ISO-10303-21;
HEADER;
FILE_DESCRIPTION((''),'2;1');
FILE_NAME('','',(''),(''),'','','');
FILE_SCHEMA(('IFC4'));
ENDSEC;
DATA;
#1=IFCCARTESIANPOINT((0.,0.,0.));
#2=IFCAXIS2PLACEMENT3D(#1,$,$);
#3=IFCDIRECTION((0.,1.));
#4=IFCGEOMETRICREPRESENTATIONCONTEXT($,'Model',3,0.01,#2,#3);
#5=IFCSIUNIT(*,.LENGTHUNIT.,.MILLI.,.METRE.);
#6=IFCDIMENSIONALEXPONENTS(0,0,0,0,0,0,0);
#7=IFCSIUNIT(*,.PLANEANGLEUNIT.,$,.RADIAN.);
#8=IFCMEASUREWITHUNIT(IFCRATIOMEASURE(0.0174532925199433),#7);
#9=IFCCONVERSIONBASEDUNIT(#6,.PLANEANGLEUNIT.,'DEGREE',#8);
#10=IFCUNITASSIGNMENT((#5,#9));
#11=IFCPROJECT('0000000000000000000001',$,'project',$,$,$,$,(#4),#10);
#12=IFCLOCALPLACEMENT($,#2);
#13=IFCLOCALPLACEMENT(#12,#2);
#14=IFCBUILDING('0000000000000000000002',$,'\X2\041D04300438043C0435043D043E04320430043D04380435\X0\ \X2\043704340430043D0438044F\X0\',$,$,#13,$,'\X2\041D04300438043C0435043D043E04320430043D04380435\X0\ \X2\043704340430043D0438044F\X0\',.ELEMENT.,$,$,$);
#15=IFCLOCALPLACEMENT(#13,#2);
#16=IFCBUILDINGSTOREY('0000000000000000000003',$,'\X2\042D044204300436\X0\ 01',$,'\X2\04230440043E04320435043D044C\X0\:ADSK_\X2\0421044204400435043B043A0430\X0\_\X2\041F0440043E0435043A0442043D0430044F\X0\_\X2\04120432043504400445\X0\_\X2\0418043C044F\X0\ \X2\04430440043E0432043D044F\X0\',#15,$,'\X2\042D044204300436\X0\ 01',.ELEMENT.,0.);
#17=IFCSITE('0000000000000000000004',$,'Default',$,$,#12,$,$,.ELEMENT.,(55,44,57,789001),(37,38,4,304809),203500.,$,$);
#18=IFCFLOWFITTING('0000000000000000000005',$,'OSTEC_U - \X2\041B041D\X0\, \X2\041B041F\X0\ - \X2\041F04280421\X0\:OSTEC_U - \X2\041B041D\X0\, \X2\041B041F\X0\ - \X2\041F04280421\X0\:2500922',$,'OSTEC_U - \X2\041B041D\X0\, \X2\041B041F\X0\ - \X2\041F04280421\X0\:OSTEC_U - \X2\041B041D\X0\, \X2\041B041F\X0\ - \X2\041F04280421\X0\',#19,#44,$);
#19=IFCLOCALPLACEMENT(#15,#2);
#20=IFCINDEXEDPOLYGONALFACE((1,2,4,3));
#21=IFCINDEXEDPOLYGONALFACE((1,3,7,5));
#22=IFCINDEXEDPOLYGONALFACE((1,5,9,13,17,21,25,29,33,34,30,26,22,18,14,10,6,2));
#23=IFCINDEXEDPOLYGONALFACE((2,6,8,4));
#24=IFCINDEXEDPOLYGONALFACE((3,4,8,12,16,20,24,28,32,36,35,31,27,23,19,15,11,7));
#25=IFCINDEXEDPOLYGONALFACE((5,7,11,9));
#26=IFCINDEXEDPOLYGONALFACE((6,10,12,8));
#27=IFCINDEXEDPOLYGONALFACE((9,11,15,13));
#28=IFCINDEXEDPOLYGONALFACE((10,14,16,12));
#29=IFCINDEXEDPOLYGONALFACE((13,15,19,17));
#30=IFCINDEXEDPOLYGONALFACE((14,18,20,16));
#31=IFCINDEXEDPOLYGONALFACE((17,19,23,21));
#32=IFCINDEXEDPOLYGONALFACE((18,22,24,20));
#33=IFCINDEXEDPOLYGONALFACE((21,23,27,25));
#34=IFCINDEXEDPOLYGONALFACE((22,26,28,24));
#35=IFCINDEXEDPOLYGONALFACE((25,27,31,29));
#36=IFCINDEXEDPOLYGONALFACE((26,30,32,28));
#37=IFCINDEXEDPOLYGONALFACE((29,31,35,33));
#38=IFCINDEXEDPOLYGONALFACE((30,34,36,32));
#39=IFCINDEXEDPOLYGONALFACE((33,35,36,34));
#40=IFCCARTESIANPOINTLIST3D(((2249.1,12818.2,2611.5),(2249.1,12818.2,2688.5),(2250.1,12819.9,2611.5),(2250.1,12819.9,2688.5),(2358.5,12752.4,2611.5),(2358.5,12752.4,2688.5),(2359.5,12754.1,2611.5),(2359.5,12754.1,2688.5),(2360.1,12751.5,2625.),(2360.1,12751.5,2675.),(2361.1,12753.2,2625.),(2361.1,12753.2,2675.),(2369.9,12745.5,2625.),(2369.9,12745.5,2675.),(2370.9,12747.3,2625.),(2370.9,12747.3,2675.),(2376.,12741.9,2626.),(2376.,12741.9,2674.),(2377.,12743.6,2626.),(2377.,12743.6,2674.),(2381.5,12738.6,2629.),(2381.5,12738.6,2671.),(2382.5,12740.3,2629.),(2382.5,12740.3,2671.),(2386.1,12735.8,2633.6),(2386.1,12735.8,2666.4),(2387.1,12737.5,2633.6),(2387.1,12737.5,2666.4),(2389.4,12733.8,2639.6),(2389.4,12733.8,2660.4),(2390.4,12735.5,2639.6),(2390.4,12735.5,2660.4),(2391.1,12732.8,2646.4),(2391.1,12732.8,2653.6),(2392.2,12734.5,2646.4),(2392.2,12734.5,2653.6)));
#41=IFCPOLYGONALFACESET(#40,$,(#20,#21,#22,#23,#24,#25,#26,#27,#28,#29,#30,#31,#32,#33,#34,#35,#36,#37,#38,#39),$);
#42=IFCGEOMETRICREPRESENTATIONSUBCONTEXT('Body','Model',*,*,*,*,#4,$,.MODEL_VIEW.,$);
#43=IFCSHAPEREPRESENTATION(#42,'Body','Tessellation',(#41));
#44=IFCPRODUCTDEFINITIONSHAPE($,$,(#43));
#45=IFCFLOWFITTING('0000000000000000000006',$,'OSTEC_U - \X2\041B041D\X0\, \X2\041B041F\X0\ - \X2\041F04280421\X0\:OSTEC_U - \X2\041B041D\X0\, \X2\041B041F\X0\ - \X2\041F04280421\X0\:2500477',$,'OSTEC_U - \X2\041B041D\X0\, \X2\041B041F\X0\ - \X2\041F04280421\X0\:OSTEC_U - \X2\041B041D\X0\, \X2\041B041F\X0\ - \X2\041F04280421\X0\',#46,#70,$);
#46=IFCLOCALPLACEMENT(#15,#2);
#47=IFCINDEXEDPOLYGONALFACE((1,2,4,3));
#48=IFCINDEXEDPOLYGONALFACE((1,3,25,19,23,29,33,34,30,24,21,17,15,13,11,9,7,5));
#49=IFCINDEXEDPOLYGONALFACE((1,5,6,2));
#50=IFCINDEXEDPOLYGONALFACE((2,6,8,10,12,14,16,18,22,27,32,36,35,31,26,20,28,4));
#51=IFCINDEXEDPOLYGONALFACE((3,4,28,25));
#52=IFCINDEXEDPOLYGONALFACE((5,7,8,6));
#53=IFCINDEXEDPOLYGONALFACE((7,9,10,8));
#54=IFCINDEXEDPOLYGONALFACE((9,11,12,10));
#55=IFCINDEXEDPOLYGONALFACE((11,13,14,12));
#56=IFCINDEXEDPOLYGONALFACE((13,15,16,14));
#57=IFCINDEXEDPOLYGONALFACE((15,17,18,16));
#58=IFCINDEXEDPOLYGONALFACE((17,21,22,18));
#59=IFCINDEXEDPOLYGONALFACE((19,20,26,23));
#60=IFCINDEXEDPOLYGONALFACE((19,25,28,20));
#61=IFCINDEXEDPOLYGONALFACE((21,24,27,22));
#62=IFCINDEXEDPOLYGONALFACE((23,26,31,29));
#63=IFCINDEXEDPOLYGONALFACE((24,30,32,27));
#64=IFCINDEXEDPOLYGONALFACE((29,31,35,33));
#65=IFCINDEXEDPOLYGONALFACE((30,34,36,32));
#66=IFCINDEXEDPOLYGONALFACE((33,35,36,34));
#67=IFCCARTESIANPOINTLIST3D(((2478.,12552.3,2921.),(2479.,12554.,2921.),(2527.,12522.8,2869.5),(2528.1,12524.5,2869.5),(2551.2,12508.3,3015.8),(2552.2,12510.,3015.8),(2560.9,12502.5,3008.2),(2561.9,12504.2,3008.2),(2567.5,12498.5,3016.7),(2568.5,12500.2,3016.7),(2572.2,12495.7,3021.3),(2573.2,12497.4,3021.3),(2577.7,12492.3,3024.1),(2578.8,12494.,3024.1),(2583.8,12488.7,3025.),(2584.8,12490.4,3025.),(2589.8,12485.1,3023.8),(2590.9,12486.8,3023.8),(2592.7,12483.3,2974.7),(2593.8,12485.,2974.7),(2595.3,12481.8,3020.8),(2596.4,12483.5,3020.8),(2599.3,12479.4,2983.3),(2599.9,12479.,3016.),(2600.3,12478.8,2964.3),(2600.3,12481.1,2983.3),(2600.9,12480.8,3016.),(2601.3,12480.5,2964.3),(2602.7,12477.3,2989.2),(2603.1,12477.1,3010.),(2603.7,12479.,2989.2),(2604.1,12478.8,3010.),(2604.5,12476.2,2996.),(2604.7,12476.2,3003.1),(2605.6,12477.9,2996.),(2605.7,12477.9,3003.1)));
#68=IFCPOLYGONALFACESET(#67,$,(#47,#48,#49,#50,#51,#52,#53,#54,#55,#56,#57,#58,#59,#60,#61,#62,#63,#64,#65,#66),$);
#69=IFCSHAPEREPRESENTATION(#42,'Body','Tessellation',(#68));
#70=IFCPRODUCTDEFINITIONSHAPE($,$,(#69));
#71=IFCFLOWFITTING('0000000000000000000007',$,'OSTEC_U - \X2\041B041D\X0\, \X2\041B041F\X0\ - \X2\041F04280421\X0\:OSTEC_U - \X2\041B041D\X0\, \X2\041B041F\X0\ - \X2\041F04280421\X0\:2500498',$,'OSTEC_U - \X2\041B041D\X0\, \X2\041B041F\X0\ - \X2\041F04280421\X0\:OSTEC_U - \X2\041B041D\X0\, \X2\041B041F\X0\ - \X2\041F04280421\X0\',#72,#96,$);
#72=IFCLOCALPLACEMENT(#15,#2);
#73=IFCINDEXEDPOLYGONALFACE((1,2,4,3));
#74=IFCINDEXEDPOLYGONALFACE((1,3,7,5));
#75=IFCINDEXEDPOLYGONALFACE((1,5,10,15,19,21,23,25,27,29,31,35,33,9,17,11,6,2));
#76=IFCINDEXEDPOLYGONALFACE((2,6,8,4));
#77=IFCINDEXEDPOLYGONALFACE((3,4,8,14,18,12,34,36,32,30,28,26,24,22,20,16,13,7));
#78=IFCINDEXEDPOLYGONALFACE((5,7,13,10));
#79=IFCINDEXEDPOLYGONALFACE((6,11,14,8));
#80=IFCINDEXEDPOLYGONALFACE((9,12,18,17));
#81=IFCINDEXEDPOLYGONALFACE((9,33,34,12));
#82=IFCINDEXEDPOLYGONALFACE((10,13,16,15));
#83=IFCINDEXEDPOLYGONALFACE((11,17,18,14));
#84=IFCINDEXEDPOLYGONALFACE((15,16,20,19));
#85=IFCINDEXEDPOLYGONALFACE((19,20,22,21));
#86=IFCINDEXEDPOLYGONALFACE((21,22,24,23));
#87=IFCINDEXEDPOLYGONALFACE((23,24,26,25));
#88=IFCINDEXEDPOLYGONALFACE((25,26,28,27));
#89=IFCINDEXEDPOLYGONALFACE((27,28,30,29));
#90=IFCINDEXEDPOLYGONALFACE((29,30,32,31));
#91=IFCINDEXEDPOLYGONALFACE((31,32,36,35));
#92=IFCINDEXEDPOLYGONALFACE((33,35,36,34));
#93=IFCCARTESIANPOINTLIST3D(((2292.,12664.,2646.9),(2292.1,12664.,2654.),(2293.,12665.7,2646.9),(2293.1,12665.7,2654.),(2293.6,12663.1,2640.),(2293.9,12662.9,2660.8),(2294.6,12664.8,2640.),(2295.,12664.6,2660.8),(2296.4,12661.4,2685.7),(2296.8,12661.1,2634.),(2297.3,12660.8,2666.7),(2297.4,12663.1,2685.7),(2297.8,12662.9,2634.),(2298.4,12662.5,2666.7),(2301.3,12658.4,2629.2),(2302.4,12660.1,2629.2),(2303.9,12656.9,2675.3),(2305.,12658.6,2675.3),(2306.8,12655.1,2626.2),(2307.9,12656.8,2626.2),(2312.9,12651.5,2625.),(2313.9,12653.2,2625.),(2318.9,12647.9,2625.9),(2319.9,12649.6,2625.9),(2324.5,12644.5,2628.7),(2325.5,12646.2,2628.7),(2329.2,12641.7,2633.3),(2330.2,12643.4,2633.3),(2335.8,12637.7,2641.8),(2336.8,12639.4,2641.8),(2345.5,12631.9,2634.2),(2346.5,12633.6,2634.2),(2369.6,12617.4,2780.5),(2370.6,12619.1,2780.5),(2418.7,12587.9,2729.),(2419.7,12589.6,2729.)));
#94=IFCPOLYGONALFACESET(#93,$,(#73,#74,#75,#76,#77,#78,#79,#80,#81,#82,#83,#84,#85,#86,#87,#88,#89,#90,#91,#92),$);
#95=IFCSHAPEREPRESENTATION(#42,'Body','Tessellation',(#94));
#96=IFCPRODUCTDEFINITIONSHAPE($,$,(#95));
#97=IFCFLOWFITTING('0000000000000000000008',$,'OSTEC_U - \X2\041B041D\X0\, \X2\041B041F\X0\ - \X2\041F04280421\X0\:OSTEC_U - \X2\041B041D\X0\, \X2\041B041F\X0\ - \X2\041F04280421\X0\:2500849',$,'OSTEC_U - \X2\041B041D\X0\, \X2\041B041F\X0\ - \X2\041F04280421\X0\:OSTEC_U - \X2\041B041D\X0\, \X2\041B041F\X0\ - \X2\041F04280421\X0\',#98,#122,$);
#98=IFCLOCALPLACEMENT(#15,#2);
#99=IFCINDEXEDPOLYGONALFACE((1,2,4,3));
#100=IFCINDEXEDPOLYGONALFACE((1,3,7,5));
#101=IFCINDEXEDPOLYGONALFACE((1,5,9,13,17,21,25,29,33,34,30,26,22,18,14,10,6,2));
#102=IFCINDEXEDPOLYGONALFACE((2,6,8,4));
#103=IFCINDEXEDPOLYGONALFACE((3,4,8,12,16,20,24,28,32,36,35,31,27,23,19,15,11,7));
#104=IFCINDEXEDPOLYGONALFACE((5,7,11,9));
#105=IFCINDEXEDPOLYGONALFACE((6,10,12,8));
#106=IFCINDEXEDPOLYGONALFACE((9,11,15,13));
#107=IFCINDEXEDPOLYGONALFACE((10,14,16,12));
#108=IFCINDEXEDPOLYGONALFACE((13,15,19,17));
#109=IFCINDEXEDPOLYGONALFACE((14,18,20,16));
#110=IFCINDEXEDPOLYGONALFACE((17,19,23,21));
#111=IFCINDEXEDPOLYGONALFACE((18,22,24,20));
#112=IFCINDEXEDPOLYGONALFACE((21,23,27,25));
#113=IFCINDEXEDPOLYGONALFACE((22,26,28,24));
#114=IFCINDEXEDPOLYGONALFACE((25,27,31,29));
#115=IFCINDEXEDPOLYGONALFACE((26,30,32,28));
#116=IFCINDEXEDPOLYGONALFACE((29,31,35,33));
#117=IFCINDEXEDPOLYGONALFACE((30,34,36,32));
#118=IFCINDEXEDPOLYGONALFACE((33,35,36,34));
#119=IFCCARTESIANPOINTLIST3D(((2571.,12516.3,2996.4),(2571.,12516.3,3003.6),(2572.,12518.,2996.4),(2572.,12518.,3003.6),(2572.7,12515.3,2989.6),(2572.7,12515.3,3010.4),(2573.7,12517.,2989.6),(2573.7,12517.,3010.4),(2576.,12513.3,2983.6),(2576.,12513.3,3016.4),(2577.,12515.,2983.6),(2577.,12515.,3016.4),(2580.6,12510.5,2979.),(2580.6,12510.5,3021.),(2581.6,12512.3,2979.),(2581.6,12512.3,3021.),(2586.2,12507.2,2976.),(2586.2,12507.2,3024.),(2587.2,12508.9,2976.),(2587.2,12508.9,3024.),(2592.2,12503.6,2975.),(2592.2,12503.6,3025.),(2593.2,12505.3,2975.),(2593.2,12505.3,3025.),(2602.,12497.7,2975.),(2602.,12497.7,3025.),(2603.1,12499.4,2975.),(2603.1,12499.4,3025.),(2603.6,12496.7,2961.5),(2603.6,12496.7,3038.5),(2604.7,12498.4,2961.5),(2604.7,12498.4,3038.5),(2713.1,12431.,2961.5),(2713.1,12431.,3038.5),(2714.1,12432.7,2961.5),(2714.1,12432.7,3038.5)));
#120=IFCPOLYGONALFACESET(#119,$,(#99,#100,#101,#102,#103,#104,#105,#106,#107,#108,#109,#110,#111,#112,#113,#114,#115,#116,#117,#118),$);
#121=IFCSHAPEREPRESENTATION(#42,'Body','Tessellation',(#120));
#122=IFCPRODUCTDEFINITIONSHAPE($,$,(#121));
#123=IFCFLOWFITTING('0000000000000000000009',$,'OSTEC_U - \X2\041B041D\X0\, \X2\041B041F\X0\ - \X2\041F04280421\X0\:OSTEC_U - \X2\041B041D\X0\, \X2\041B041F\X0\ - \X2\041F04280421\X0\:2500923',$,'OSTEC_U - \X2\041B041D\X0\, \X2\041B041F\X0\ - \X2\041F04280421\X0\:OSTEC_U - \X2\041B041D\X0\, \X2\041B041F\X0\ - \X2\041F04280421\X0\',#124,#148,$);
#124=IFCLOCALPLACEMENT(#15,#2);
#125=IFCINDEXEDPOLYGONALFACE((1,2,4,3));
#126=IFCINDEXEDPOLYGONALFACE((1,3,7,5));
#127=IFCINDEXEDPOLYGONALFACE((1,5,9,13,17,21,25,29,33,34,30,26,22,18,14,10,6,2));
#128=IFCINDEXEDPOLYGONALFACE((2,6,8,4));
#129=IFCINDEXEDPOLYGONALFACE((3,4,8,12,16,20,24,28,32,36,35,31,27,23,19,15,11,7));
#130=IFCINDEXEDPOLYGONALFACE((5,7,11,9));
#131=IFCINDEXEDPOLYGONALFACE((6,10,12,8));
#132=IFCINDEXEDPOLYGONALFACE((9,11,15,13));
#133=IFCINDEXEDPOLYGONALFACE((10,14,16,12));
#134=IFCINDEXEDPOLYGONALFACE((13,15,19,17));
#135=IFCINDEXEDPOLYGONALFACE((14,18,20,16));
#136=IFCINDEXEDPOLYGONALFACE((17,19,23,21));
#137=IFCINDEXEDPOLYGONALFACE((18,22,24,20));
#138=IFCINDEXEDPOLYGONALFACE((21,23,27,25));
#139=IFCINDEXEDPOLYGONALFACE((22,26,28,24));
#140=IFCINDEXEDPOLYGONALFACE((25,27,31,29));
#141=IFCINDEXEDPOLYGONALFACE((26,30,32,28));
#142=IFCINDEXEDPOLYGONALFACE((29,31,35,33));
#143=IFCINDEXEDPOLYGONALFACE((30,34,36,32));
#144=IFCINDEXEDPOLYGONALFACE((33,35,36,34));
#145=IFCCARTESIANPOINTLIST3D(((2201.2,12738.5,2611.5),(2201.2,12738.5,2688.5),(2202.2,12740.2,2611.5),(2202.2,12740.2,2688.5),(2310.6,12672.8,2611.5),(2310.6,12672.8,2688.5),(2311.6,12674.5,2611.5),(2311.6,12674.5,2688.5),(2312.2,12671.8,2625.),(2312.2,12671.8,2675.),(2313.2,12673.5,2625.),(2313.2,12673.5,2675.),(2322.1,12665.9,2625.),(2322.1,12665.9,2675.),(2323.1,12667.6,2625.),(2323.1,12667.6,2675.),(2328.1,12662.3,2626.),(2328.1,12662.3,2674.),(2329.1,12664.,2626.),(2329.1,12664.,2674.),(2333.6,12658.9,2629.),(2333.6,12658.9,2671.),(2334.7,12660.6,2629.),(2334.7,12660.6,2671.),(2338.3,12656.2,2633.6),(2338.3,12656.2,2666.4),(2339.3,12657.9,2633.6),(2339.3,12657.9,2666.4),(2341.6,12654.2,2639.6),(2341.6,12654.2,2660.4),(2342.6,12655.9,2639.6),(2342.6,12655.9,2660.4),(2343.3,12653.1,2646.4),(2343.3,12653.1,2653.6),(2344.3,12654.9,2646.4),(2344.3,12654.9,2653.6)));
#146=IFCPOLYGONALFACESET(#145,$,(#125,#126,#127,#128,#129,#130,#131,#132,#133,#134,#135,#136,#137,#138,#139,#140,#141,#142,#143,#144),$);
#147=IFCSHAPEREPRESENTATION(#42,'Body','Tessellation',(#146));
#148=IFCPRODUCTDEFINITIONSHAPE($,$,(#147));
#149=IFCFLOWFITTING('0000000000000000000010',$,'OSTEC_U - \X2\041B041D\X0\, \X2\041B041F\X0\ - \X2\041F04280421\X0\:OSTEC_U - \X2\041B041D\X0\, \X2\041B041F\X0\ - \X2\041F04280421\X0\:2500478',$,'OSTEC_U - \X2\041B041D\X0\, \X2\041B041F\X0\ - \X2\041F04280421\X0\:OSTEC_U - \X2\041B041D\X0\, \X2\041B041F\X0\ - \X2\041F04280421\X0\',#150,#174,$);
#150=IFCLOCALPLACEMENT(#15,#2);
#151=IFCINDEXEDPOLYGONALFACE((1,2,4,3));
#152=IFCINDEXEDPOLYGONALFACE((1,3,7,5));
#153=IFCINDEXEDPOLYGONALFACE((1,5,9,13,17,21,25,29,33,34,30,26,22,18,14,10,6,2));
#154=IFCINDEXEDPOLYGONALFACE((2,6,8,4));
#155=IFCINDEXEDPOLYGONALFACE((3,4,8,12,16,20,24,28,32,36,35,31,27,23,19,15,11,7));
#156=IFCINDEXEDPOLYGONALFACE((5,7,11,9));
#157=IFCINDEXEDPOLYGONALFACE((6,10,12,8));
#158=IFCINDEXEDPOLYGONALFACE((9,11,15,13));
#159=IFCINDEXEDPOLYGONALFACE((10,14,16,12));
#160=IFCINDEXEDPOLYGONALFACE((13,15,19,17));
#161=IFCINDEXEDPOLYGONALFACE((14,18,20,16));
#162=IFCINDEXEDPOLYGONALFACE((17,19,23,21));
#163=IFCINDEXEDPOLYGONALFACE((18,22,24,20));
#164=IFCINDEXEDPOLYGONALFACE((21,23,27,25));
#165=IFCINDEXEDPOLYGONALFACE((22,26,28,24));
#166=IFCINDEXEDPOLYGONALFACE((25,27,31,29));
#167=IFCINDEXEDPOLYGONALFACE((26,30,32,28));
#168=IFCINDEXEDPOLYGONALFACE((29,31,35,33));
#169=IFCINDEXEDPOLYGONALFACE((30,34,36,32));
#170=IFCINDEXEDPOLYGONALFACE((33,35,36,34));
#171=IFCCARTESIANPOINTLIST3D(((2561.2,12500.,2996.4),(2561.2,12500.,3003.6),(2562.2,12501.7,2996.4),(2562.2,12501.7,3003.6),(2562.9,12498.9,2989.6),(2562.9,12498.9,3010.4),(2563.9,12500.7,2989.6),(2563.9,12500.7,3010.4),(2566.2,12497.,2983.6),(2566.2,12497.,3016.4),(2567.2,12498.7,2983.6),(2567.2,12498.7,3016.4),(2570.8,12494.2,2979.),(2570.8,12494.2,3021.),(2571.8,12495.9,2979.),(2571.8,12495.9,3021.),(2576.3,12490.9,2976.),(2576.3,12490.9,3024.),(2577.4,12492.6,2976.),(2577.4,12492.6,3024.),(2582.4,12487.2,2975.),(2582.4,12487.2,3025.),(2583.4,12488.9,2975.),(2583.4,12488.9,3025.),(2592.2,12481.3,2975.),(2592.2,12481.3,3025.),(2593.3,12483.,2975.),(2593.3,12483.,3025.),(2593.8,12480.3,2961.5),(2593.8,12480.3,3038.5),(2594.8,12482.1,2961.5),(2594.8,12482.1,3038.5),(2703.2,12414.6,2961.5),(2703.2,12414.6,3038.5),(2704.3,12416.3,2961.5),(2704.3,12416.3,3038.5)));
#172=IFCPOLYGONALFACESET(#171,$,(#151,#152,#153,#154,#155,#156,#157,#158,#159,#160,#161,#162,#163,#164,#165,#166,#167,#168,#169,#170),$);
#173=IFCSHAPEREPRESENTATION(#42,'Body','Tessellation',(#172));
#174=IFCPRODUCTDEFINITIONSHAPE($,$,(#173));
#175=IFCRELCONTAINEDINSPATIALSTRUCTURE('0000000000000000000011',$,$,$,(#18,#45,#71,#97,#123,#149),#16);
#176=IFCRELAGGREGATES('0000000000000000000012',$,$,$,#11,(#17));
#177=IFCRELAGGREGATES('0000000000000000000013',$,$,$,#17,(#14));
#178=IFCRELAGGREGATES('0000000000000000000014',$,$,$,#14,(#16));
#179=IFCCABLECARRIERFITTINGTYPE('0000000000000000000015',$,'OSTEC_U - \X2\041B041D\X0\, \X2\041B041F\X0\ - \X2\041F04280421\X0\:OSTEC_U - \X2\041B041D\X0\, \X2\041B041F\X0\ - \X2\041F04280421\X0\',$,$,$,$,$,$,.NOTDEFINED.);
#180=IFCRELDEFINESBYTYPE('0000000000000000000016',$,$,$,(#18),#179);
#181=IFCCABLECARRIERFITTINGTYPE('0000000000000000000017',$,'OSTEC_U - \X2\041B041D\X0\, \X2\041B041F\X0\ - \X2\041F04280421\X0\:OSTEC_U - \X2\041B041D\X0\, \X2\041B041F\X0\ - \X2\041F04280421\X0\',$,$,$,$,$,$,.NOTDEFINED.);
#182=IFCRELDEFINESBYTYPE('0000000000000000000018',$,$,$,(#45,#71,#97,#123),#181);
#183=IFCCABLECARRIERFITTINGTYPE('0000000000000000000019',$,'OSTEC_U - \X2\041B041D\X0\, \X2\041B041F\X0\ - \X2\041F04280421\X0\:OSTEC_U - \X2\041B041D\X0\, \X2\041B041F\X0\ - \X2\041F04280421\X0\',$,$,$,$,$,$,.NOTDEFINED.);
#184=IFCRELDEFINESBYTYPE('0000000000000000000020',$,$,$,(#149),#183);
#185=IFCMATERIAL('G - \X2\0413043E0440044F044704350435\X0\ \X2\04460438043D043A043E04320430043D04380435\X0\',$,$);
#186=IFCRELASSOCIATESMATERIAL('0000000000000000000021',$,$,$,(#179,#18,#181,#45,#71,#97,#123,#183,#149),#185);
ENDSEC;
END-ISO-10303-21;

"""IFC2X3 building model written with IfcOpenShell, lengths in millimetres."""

from ifc_helpers import new_model, entity, si_unit, converted_unit, direction, frame, frame_2d, origin, place, context, subcontext, project, spatial, polyline, circle_curve, parameter, trimmed, segment, composite_curve, outline, extrude, source, transform, mapped, material, type_object, type_shapes, element, save


model = new_model("IFC2X3")

# Units and contexts
model_context = context("Model", 3, precision=0.01, world=origin(), true_north=direction((0.0, 1.0)))
body_context = subcontext(model_context, "Body", "Model", "MODEL_VIEW")
ifc_project = project(units=[si_unit("LENGTHUNIT", "METRE", prefix="MILLI"), converted_unit("PLANEANGLEUNIT", "DEGREE", entity("IfcRatioMeasure", 0.0174532925199433), si_unit("PLANEANGLEUNIT", "RADIAN"), dimensions=[0, 0, 0, 0, 0, 0, 0])], contexts=[model_context])

# Site, building, storey
site_placement = place(None, frame((0.0, 0.0, 0.0)))
site = spatial("IfcSite", under=ifc_project, at=site_placement, Name="Default", CompositionType="ELEMENT", RefLatitude=(55, 44, 57, 789001), RefLongitude=(37, 38, 4, 304809), RefElevation=203500.0)
building_placement = place(site_placement, origin())
building = spatial("IfcBuilding", under=site, at=building_placement, Name="Наименование здания", LongName="Наименование здания", CompositionType="ELEMENT")
storey_placement = place(building_placement, origin())
storey = spatial("IfcBuildingStorey", under=building, at=storey_placement, Name="Этаж 01", ObjectType="Уровень:ADSK_Стрелка_Проектная_Вверх_Имя уровня", LongName="Этаж 01", CompositionType="ELEMENT", Elevation=0.0)

# Flow fittings
ifc_material_1 = material(Name="G - Горячее цинкование")
cable_carrier_fitting_type_1 = type_object("IfcCableCarrierFittingType", Name="OSTEC_U - ЛН, ЛП - ПШС:OSTEC_U - ЛН, ЛП - ПШС", PredefinedType="NOTDEFINED", material=ifc_material_1)
shared_shape_1 = source(origin(), body_context, "Body", "SweptSolid", [
    extrude(outline(composite_curve([segment(trimmed(circle_curve(frame_2d((-41.5, 0.0), x_axis=(1.0, 0.0)), 25.0), [parameter(90.0)], [parameter(270.0)], True, "PARAMETER"), True, "CONTINUOUS"), segment(polyline([(-41.5, -25.0), (-30.0, -25.0)]), True, "CONTINUOUS"), segment(polyline([(-30.0, -25.0), (-28.1, -38.5)]), True, "CONTINUOUS"), segment(polyline([(-28.1, -38.5), (99.5, -38.5)]), True, "CONTINUOUS"), segment(polyline([(99.5, -38.5), (99.5, 38.5)]), True, "CONTINUOUS"), segment(polyline([(99.5, 38.5), (-28.1, 38.5)]), True, "CONTINUOUS"), segment(polyline([(-28.1, 38.5), (-30.0, 25.0)]), True, "CONTINUOUS"), segment(polyline([(-30.0, 25.0), (-41.5, 25.0)]), True, "CONTINUOUS")], self_intersect=False)), frame((41.5, 0.0, 0.0), z_axis=(0.0, 0.0, -1.0), x_axis=(1.0, 0.0, 0.0)), (0.0, 0.0, -1.0), 2.0),
])
type_shapes(cable_carrier_fitting_type_1, [shared_shape_1])
for number, where, z_axis, x_axis, name in (
    (1, (2369.9, 12745.5, 2650.0), (0.515038, 0.857167, 0.0), (-0.857167, 0.515038, 0.0), "OSTEC_U - ЛН, ЛП - ПШС:OSTEC_U - ЛН, ЛП - ПШС:2500922"),
):
    element("IfcFlowFitting", number, at=place(storey_placement, frame(where, z_axis=z_axis, x_axis=x_axis)), inside=storey, type_object=cable_carrier_fitting_type_1, material=ifc_material_1, Name=name, ObjectType="OSTEC_U - ЛН, ЛП - ПШС:OSTEC_U - ЛН, ЛП - ПШС", context=body_context, shape_type="MappedRepresentation", body=[
        mapped(shared_shape_1, transform((0.0, 0.0, 0.0), scale=1.0)),
    ])
cable_carrier_fitting_type_2 = type_object("IfcCableCarrierFittingType", Name="OSTEC_U - ЛН, ЛП - ПШС:OSTEC_U - ЛН, ЛП - ПШС", PredefinedType="NOTDEFINED", material=ifc_material_1)
shared_shape_2 = source(origin(), body_context, "Body", "SweptSolid", [
    extrude(outline(composite_curve([segment(trimmed(circle_curve(frame_2d((-41.5, 0.0), x_axis=(1.0, 0.0)), 25.0), [parameter(90.0)], [parameter(270.0)], True, "PARAMETER"), True, "CONTINUOUS"), segment(polyline([(-41.5, -25.0), (-30.0, -25.0)]), True, "CONTINUOUS"), segment(polyline([(-30.0, -25.0), (-28.1, -38.5)]), True, "CONTINUOUS"), segment(polyline([(-28.1, -38.5), (99.5, -38.5)]), True, "CONTINUOUS"), segment(polyline([(99.5, -38.5), (99.5, 38.5)]), True, "CONTINUOUS"), segment(polyline([(99.5, 38.5), (-28.1, 38.5)]), True, "CONTINUOUS"), segment(polyline([(-28.1, 38.5), (-30.0, 25.0)]), True, "CONTINUOUS"), segment(polyline([(-30.0, 25.0), (-41.5, 25.0)]), True, "CONTINUOUS")], self_intersect=False)), frame((41.5, 0.0, 0.0)), (0.0, 0.0, 1.0), 2.0),
])
type_shapes(cable_carrier_fitting_type_2, [shared_shape_2])
for number, where, z_axis, x_axis, name in (
    (2, (2583.4, 12488.9, 3000.0), (0.515038, 0.857167, 0.0), (-0.573557, 0.344628, -0.743145), "OSTEC_U - ЛН, ЛП - ПШС:OSTEC_U - ЛН, ЛП - ПШС:2500477"),
    (3, (2313.3, 12651.2, 2650.0), (0.515038, 0.857167, 0.0), (0.573557, -0.344628, 0.743145), "OSTEC_U - ЛН, ЛП - ПШС:OSTEC_U - ЛН, ЛП - ПШС:2500498"),
    (4, (2593.2, 12505.3, 3000.0), (-0.515038, -0.857167, 0.0), (0.857167, -0.515038, 0.0), "OSTEC_U - ЛН, ЛП - ПШС:OSTEC_U - ЛН, ЛП - ПШС:2500849"),
    (5, (2323.1, 12667.6, 2650.0), (-0.515038, -0.857167, 0.0), (-0.857167, 0.515038, 0.0), "OSTEC_U - ЛН, ЛП - ПШС:OSTEC_U - ЛН, ЛП - ПШС:2500923"),
):
    element("IfcFlowFitting", number, at=place(storey_placement, frame(where, z_axis=z_axis, x_axis=x_axis)), inside=storey, type_object=cable_carrier_fitting_type_2, material=ifc_material_1, Name=name, ObjectType="OSTEC_U - ЛН, ЛП - ПШС:OSTEC_U - ЛН, ЛП - ПШС", context=body_context, shape_type="MappedRepresentation", body=[
        mapped(shared_shape_2, transform((0.0, 0.0, 0.0), scale=1.0)),
    ])
cable_carrier_fitting_type_3 = type_object("IfcCableCarrierFittingType", Name="OSTEC_U - ЛН, ЛП - ПШС:OSTEC_U - ЛН, ЛП - ПШС", PredefinedType="NOTDEFINED", material=ifc_material_1)
shared_shape_3 = source(origin(), body_context, "Body", "SweptSolid", [
    extrude(outline(composite_curve([segment(trimmed(circle_curve(frame_2d((-41.5, 0.0), x_axis=(1.0, 0.0)), 25.0), [parameter(90.0)], [parameter(270.0)], True, "PARAMETER"), True, "CONTINUOUS"), segment(polyline([(-41.5, -25.0), (-30.0, -25.0)]), True, "CONTINUOUS"), segment(polyline([(-30.0, -25.0), (-28.1, -38.5)]), True, "CONTINUOUS"), segment(polyline([(-28.1, -38.5), (99.5, -38.5)]), True, "CONTINUOUS"), segment(polyline([(99.5, -38.5), (99.5, 38.5)]), True, "CONTINUOUS"), segment(polyline([(99.5, 38.5), (-28.1, 38.5)]), True, "CONTINUOUS"), segment(polyline([(-28.1, 38.5), (-30.0, 25.0)]), True, "CONTINUOUS"), segment(polyline([(-30.0, 25.0), (-41.5, 25.0)]), True, "CONTINUOUS")], self_intersect=False)), frame((41.5, 0.0, 0.0), z_axis=(0.0, 0.0, -1.0), x_axis=(1.0, 0.0, 0.0)), (0.0, 0.0, -1.0), 2.0),
])
type_shapes(cable_carrier_fitting_type_3, [shared_shape_3])
for number, where, z_axis, x_axis, name in (
    (6, (2582.4, 12487.2, 3000.0), (0.515038, 0.857167, 0.0), (0.857167, -0.515038, 0.0), "OSTEC_U - ЛН, ЛП - ПШС:OSTEC_U - ЛН, ЛП - ПШС:2500478"),
):
    element("IfcFlowFitting", number, at=place(storey_placement, frame(where, z_axis=z_axis, x_axis=x_axis)), inside=storey, type_object=cable_carrier_fitting_type_3, material=ifc_material_1, Name=name, ObjectType="OSTEC_U - ЛН, ЛП - ПШС:OSTEC_U - ЛН, ЛП - ПШС", context=body_context, shape_type="MappedRepresentation", body=[
        mapped(shared_shape_3, transform((0.0, 0.0, 0.0), scale=1.0)),
    ])

save(model, "model.ifc")
